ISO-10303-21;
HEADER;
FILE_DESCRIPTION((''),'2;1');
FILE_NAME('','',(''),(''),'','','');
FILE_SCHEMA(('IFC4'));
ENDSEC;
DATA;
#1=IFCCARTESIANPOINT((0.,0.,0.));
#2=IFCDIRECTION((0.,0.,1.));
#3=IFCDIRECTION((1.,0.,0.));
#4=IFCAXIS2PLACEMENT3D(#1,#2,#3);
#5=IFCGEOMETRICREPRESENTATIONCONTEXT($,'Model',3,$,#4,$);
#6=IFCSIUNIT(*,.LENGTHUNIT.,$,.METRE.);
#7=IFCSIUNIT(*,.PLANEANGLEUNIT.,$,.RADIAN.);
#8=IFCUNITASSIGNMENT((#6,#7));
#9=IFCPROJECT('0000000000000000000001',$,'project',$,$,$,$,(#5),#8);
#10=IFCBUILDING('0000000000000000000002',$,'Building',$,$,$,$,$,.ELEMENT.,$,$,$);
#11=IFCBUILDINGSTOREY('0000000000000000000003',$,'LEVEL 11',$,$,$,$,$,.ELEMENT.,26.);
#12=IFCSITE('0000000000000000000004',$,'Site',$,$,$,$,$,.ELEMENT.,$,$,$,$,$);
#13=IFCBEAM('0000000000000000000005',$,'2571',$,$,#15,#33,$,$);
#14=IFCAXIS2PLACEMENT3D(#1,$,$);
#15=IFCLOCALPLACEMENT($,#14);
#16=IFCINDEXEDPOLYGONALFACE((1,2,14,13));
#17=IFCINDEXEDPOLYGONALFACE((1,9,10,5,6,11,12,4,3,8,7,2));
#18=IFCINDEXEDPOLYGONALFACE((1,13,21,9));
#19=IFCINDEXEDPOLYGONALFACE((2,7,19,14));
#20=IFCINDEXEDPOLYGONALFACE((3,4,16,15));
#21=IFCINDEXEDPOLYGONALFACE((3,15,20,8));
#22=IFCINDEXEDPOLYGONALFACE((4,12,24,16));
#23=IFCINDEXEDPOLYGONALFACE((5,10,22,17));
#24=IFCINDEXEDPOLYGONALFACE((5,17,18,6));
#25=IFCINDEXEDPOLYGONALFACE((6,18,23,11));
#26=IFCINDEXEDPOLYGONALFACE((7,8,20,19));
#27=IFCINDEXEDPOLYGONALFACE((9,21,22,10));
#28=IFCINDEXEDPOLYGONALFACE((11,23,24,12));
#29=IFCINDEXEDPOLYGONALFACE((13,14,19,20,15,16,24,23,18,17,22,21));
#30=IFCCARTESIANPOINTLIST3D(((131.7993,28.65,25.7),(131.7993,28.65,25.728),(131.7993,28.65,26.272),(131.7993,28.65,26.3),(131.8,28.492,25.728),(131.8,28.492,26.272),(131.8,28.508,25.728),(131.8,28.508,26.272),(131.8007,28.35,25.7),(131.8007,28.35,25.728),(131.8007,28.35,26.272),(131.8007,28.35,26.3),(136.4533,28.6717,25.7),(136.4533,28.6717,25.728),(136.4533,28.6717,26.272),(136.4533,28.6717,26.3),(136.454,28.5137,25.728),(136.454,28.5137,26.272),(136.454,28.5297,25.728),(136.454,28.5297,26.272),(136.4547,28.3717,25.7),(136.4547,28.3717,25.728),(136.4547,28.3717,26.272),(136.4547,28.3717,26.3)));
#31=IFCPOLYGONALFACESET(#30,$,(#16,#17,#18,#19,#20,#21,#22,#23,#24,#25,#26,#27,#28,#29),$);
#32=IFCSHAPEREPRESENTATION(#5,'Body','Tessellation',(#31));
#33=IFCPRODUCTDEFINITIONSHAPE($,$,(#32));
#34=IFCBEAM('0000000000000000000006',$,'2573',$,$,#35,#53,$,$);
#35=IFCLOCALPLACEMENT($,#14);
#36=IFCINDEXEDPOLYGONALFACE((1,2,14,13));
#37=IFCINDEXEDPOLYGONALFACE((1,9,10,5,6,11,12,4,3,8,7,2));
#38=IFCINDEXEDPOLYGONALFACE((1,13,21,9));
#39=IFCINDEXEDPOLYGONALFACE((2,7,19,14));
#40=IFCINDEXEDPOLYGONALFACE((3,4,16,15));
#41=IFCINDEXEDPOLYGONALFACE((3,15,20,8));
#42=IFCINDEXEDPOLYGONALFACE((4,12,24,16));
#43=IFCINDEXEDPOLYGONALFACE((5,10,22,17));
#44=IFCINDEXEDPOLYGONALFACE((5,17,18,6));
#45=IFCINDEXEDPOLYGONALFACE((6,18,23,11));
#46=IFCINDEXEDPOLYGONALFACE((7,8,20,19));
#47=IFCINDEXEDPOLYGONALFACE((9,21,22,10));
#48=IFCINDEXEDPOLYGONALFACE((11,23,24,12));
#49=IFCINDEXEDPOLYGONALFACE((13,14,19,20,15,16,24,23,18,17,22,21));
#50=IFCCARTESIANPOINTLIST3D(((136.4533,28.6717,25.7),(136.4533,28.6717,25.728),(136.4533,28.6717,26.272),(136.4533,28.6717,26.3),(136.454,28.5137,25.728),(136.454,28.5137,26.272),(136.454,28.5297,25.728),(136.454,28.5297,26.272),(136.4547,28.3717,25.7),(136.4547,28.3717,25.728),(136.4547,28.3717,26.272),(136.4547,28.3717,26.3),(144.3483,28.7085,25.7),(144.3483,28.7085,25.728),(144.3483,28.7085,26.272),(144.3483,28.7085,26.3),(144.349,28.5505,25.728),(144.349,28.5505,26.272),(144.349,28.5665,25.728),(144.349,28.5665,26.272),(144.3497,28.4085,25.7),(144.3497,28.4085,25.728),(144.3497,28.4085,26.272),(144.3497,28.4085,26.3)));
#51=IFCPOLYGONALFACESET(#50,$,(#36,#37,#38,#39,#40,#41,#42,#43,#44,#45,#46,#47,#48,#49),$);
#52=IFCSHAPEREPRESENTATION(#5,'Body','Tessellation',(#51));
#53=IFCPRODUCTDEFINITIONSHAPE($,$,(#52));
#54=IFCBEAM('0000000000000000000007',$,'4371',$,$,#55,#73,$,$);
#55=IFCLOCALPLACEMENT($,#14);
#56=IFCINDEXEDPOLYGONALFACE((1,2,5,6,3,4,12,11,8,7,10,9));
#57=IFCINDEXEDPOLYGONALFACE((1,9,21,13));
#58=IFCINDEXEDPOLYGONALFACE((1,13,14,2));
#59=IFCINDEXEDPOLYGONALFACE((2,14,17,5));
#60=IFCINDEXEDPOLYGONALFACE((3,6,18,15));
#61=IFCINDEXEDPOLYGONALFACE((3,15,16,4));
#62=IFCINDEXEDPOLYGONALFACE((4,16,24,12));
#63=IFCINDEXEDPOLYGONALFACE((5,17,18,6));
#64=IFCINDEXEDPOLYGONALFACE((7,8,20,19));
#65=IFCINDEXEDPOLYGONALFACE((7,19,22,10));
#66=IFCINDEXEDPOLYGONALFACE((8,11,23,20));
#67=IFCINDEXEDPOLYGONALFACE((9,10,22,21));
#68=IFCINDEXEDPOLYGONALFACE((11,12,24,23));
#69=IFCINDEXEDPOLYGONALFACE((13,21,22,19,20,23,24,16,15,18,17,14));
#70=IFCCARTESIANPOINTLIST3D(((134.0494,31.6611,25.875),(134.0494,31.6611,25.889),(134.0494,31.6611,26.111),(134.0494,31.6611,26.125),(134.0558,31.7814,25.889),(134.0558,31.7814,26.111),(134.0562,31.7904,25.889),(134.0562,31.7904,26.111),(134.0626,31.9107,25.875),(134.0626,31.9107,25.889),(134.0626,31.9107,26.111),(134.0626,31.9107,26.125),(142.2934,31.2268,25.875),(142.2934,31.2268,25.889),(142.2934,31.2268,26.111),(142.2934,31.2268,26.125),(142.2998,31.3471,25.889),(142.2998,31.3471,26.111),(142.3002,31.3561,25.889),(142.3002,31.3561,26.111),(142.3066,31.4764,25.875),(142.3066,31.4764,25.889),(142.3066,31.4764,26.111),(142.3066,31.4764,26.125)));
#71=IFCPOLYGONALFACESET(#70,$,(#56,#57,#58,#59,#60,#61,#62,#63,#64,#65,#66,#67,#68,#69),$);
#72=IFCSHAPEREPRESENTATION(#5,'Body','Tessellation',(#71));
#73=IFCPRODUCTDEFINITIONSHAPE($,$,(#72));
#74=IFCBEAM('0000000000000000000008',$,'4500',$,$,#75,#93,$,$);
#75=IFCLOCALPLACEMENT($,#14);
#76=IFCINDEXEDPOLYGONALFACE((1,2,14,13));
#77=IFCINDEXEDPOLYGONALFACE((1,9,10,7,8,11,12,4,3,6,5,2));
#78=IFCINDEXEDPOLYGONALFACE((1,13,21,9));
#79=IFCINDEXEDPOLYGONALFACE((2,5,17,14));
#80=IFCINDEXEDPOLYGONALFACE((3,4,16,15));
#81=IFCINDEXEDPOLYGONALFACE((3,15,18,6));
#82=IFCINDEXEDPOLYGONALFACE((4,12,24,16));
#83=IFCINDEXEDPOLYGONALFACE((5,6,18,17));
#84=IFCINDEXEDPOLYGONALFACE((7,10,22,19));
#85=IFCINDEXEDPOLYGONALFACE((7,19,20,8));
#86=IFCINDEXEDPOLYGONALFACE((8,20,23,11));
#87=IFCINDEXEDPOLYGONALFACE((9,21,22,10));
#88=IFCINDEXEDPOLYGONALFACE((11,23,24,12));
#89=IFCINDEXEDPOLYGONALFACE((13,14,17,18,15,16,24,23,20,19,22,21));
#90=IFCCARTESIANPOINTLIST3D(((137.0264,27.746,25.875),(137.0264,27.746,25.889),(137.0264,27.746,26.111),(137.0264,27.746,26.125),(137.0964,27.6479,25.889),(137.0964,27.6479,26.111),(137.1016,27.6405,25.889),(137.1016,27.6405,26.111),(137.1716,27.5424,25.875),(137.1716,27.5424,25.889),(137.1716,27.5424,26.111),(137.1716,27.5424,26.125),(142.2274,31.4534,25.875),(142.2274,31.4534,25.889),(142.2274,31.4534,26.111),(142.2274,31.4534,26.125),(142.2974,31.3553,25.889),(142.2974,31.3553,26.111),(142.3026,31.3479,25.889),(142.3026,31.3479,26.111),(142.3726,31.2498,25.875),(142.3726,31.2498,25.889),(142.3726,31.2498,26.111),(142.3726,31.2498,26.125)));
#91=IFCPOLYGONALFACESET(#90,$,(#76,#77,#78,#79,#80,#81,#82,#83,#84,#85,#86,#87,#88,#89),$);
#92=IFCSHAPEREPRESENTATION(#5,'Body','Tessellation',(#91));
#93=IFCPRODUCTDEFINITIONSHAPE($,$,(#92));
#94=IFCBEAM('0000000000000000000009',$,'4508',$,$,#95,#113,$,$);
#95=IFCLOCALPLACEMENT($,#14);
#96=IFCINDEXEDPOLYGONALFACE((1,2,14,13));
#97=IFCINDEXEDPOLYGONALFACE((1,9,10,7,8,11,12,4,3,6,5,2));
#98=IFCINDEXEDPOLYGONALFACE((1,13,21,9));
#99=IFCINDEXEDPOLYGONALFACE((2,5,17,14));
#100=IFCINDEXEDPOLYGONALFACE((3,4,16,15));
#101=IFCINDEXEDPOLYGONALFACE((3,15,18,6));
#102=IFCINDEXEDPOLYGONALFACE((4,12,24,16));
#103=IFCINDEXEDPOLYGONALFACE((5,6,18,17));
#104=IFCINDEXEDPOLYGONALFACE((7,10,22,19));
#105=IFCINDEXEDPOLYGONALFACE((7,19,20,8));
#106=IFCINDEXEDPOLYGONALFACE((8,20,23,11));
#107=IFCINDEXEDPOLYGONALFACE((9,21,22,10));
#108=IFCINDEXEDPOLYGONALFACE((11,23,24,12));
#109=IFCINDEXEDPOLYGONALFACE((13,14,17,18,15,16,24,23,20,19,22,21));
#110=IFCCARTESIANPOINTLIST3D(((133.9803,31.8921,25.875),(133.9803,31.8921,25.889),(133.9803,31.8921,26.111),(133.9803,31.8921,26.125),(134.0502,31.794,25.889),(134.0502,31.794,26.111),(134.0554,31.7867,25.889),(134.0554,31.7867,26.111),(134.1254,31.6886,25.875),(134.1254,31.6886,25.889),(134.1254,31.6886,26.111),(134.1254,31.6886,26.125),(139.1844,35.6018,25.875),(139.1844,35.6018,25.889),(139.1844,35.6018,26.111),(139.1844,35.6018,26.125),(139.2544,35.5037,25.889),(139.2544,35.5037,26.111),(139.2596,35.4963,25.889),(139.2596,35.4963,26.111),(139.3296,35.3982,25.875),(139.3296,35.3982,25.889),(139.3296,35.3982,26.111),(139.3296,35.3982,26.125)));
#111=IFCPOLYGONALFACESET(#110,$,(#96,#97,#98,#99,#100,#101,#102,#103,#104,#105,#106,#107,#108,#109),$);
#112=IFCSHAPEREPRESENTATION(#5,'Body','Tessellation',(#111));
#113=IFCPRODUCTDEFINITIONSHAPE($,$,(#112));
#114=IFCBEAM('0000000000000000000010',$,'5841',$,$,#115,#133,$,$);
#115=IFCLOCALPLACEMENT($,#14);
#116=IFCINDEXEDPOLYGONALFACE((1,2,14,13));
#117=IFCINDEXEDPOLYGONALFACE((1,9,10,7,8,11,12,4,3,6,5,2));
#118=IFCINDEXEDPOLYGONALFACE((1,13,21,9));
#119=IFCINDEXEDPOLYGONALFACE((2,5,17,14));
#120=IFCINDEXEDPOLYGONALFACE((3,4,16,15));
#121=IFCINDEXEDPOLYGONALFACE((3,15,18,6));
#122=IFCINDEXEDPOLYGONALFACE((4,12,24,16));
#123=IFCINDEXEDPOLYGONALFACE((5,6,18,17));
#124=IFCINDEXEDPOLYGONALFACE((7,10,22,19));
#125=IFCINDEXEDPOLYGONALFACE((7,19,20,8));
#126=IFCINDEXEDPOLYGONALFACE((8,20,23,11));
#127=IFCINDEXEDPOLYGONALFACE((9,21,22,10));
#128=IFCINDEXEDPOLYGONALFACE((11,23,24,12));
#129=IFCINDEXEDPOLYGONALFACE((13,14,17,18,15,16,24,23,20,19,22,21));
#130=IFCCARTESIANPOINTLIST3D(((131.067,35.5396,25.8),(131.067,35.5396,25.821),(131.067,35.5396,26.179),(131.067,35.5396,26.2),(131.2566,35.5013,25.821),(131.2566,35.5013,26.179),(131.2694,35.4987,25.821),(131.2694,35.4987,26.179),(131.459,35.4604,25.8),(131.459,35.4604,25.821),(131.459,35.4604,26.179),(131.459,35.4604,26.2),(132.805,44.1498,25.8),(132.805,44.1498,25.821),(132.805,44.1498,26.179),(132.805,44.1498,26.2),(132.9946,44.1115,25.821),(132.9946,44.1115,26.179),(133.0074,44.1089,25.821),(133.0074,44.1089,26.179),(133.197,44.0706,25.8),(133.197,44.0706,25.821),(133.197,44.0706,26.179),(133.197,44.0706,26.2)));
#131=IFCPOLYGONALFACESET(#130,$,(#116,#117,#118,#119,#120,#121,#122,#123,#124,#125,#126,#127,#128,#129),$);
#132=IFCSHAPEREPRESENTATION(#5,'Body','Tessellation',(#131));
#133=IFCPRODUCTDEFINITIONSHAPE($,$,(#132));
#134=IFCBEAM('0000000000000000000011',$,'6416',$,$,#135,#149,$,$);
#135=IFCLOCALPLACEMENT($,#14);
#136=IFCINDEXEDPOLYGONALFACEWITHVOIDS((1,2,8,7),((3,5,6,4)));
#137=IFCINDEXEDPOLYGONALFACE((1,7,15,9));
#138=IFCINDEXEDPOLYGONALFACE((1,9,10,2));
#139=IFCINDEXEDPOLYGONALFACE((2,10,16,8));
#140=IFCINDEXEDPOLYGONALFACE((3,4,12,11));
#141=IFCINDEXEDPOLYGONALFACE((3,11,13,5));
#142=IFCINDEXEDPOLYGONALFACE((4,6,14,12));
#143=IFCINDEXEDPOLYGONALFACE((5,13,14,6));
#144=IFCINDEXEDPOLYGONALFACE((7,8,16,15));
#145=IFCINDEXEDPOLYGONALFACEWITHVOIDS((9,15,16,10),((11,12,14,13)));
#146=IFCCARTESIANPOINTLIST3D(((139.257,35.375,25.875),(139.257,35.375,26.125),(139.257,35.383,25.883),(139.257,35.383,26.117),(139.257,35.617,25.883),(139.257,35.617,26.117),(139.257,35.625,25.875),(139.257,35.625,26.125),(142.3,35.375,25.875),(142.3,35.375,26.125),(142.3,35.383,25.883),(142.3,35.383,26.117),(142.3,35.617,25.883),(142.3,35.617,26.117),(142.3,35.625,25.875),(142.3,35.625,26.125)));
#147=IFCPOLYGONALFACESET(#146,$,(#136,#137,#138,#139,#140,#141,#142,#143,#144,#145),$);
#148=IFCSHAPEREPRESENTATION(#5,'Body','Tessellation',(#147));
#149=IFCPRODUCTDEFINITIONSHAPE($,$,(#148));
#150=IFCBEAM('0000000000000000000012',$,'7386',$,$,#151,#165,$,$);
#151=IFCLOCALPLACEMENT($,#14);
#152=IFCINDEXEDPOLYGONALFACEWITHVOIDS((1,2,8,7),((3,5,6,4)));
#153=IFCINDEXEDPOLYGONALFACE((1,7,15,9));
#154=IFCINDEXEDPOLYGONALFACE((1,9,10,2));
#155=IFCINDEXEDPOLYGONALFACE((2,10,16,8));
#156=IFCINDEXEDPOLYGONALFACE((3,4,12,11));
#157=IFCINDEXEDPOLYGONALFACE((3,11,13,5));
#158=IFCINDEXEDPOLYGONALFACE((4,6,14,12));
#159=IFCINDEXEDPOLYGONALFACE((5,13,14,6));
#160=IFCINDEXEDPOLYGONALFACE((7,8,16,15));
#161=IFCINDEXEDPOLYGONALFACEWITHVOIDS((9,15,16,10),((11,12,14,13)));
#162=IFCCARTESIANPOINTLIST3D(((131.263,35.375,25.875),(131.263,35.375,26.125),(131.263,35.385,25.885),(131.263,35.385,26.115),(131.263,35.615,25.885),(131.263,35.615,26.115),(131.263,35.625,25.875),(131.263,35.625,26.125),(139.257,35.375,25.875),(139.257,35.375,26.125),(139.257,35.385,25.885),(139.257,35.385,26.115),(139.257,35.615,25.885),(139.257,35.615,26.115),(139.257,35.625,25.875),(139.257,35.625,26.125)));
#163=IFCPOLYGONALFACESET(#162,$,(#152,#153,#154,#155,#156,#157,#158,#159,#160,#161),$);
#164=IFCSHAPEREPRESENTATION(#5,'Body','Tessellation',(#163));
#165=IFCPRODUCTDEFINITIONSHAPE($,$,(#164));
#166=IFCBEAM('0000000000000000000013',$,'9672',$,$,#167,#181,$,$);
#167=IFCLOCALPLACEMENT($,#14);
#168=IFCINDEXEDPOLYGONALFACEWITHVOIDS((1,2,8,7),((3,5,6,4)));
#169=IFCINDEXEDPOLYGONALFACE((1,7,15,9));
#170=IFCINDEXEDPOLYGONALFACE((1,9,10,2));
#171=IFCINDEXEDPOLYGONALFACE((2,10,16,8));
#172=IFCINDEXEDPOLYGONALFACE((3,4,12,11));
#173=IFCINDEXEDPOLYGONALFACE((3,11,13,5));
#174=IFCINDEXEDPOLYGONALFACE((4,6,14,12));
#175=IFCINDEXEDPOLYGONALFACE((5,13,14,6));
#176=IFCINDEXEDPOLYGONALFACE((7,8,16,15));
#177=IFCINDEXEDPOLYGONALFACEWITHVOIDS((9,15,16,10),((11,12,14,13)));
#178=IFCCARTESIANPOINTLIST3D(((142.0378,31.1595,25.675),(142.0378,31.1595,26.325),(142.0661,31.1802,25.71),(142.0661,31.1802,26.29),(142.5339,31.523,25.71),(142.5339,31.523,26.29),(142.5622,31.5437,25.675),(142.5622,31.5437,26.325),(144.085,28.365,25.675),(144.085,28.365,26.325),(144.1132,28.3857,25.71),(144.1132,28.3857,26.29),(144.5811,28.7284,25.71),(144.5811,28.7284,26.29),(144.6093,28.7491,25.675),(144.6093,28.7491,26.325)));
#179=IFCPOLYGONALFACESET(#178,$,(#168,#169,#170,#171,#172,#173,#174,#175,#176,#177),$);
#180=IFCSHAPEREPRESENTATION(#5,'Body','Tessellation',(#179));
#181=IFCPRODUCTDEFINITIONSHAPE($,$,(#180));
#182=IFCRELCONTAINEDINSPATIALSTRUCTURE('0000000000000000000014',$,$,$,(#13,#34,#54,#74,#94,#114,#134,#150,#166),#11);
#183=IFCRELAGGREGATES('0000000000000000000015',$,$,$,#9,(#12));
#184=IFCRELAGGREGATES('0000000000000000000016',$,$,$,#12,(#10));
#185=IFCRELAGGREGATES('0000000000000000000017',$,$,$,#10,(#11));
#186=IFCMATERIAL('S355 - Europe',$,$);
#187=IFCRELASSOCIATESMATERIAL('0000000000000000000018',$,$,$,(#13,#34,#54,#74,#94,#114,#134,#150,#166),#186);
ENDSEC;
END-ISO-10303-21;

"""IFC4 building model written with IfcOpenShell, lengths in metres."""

from ifc_helpers import new_model, si_unit, frame, origin_with_axes, origin_2d_with_axis, place, context, project, spatial, hollow_rectangle, i_section, extrude, material, material_profile, profile_set, profile_usage, element, save


model = new_model("IFC4")

# Units and contexts
model_context = context("Model", 3, world=origin_with_axes())
ifc_project = project(units=[si_unit("LENGTHUNIT", "METRE"), si_unit("PLANEANGLEUNIT", "RADIAN")], contexts=[model_context])

# Site, building, storey
site = spatial("IfcSite", under=ifc_project, Name="Site", CompositionType="ELEMENT")
building = spatial("IfcBuilding", under=site, Name="Building", CompositionType="ELEMENT")
storey = spatial("IfcBuildingStorey", under=building, Name="LEVEL 11", CompositionType="ELEMENT", Elevation=26.0)

# Shared definitions
ifc_material = material(Name="S355 - Europe")

# Beams
ifc_material_profile_1 = material_profile(ifc_material, i_section(OverallWidth=0.3, OverallDepth=0.6, WebThickness=0.016, FlangeThickness=0.028, at=origin_2d_with_axis()))
ifc_profile_set_1 = profile_set([ifc_material_profile_1])
ifc_profile_usage_1 = profile_usage(ifc_profile_set_1, cardinal=10)
beam_1_placement = place(None, frame((131.8, 28.5, 26.0), z_axis=(0.999989, 0.004663, 0.0), x_axis=(-0.004663, 0.999989, 0.0)))
element("IfcBeam", 1, at=beam_1_placement, inside=storey, material=ifc_profile_usage_1, Name="2571", context=model_context, shape_type="SweptSolid", body=[
    extrude(i_section(OverallWidth=0.3, OverallDepth=0.6, WebThickness=0.016, FlangeThickness=0.028, at=origin_2d_with_axis()), origin_with_axes(), (0.0, 0.0, 1.0), 4.6541),
])
ifc_material_profile_2 = material_profile(ifc_material, i_section(OverallWidth=0.3, OverallDepth=0.6, WebThickness=0.016, FlangeThickness=0.028, at=origin_2d_with_axis()))
ifc_profile_set_2 = profile_set([ifc_material_profile_2])
ifc_profile_usage_2 = profile_usage(ifc_profile_set_2, cardinal=10)
beam_2_placement = place(None, frame((136.454, 28.5217, 26.0), z_axis=(0.999989, 0.004663, 0.0), x_axis=(-0.004663, 0.999989, 0.0)))
element("IfcBeam", 2, at=beam_2_placement, inside=storey, material=ifc_profile_usage_2, Name="2573", context=model_context, shape_type="SweptSolid", body=[
    extrude(i_section(OverallWidth=0.3, OverallDepth=0.6, WebThickness=0.016, FlangeThickness=0.028, at=origin_2d_with_axis()), origin_with_axes(), (0.0, 0.0, 1.0), 7.8951),
])
ifc_material_profile_3 = material_profile(ifc_material, i_section(OverallWidth=0.25, OverallDepth=0.25, WebThickness=0.009, FlangeThickness=0.014, at=origin_2d_with_axis()))
ifc_profile_set_3 = profile_set([ifc_material_profile_3])
ifc_profile_usage_3 = profile_usage(ifc_profile_set_3, cardinal=10)
beam_3_placement = place(None, frame((142.3, 31.3516, 26.0), z_axis=(-0.998615, 0.052608, 0.0), x_axis=(-0.052608, -0.998615, 0.0)))
element("IfcBeam", 3, at=beam_3_placement, inside=storey, material=ifc_profile_usage_3, Name="4371", context=model_context, shape_type="SweptSolid", body=[
    extrude(i_section(OverallWidth=0.25, OverallDepth=0.25, WebThickness=0.009, FlangeThickness=0.014, at=origin_2d_with_axis()), origin_with_axes(), (0.0, 0.0, 1.0), 8.2554),
])
ifc_material_profile_4 = material_profile(ifc_material, i_section(OverallWidth=0.25, OverallDepth=0.25, WebThickness=0.009, FlangeThickness=0.014, at=origin_2d_with_axis()))
ifc_profile_set_4 = profile_set([ifc_material_profile_4])
ifc_profile_usage_4 = profile_usage(ifc_profile_set_4, cardinal=10)
beam_4_placement = place(None, frame((142.3, 31.3516, 26.0), z_axis=(-0.814296, -0.58045, 0.0), x_axis=(0.58045, -0.814296, 0.0)))
element("IfcBeam", 4, at=beam_4_placement, inside=storey, material=ifc_profile_usage_4, Name="4500", context=model_context, shape_type="SweptSolid", body=[
    extrude(i_section(OverallWidth=0.25, OverallDepth=0.25, WebThickness=0.009, FlangeThickness=0.014, at=origin_2d_with_axis()), origin_with_axes(), (0.0, 0.0, 1.0), 6.3871),
])
ifc_material_profile_5 = material_profile(ifc_material, i_section(OverallWidth=0.25, OverallDepth=0.25, WebThickness=0.009, FlangeThickness=0.014, at=origin_2d_with_axis()))
ifc_profile_set_5 = profile_set([ifc_material_profile_5])
ifc_profile_usage_5 = profile_usage(ifc_profile_set_5, cardinal=10)
beam_5_placement = place(None, frame((139.257, 35.5, 26.0), z_axis=(-0.814296, -0.58045, 0.0), x_axis=(0.58045, -0.814296, 0.0)))
element("IfcBeam", 5, at=beam_5_placement, inside=storey, material=ifc_profile_usage_5, Name="4508", context=model_context, shape_type="SweptSolid", body=[
    extrude(i_section(OverallWidth=0.25, OverallDepth=0.25, WebThickness=0.009, FlangeThickness=0.014, at=origin_2d_with_axis()), origin_with_axes(), (0.0, 0.0, 1.0), 6.391),
])
ifc_material_profile_6 = material_profile(ifc_material, i_section(OverallWidth=0.4, OverallDepth=0.4, WebThickness=0.013, FlangeThickness=0.021, at=origin_2d_with_axis()))
ifc_profile_set_6 = profile_set([ifc_material_profile_6])
ifc_profile_usage_6 = profile_usage(ifc_profile_set_6, cardinal=10)
beam_6_placement = place(None, frame((131.263, 35.5, 26.0), z_axis=(0.197863, 0.98023, 0.0), x_axis=(-0.98023, 0.197863, 0.0)))
element("IfcBeam", 6, at=beam_6_placement, inside=storey, material=ifc_profile_usage_6, Name="5841", context=model_context, shape_type="SweptSolid", body=[
    extrude(i_section(OverallWidth=0.4, OverallDepth=0.4, WebThickness=0.013, FlangeThickness=0.021, at=origin_2d_with_axis()), origin_with_axes(), (0.0, 0.0, 1.0), 8.7839),
])
ifc_material_profile_7 = material_profile(ifc_material, hollow_rectangle(XDim=0.25, YDim=0.25, WallThickness=0.008, at=origin_2d_with_axis()))
ifc_profile_set_7 = profile_set([ifc_material_profile_7])
ifc_profile_usage_7 = profile_usage(ifc_profile_set_7, cardinal=10)
beam_7_placement = place(None, frame((139.257, 35.5, 26.0), z_axis=(1.0, 0.0, 0.0), x_axis=(0.0, 1.0, 0.0)))
element("IfcBeam", 7, at=beam_7_placement, inside=storey, material=ifc_profile_usage_7, Name="6416", context=model_context, shape_type="SweptSolid", body=[
    extrude(hollow_rectangle(XDim=0.25, YDim=0.25, WallThickness=0.008, at=origin_2d_with_axis()), origin_with_axes(), (0.0, 0.0, 1.0), 3.043),
])
ifc_material_profile_8 = material_profile(ifc_material, hollow_rectangle(XDim=0.25, YDim=0.25, WallThickness=0.01, at=origin_2d_with_axis()))
ifc_profile_set_8 = profile_set([ifc_material_profile_8])
ifc_profile_usage_8 = profile_usage(ifc_profile_set_8, cardinal=10)
beam_8_placement = place(None, frame((131.263, 35.5, 26.0), z_axis=(1.0, 0.0, 0.0), x_axis=(0.0, 1.0, 0.0)))
element("IfcBeam", 8, at=beam_8_placement, inside=storey, material=ifc_profile_usage_8, Name="7386", context=model_context, shape_type="SweptSolid", body=[
    extrude(hollow_rectangle(XDim=0.25, YDim=0.25, WallThickness=0.01, at=origin_2d_with_axis()), origin_with_axes(), (0.0, 0.0, 1.0), 7.994),
])
ifc_material_profile_9 = material_profile(ifc_material, hollow_rectangle(XDim=0.65, YDim=0.65, WallThickness=0.035, at=origin_2d_with_axis()))
ifc_profile_set_9 = profile_set([ifc_material_profile_9])
ifc_profile_usage_9 = profile_usage(ifc_profile_set_9, cardinal=10)
beam_9_placement = place(None, frame((142.3, 31.3516, 26.0), z_axis=(0.590953, -0.806706, 0.0), x_axis=(0.806353, 0.591435, 0.0)))
element("IfcBeam", 9, at=beam_9_placement, inside=storey, material=ifc_profile_usage_9, Name="9672", context=model_context, shape_type="SweptSolid", body=[
    extrude(hollow_rectangle(XDim=0.65, YDim=0.65, WallThickness=0.035, at=origin_2d_with_axis()), origin_with_axes(), (0.0, 0.0, 1.0), 3.4642),
])

save(model, "model.ifc")
